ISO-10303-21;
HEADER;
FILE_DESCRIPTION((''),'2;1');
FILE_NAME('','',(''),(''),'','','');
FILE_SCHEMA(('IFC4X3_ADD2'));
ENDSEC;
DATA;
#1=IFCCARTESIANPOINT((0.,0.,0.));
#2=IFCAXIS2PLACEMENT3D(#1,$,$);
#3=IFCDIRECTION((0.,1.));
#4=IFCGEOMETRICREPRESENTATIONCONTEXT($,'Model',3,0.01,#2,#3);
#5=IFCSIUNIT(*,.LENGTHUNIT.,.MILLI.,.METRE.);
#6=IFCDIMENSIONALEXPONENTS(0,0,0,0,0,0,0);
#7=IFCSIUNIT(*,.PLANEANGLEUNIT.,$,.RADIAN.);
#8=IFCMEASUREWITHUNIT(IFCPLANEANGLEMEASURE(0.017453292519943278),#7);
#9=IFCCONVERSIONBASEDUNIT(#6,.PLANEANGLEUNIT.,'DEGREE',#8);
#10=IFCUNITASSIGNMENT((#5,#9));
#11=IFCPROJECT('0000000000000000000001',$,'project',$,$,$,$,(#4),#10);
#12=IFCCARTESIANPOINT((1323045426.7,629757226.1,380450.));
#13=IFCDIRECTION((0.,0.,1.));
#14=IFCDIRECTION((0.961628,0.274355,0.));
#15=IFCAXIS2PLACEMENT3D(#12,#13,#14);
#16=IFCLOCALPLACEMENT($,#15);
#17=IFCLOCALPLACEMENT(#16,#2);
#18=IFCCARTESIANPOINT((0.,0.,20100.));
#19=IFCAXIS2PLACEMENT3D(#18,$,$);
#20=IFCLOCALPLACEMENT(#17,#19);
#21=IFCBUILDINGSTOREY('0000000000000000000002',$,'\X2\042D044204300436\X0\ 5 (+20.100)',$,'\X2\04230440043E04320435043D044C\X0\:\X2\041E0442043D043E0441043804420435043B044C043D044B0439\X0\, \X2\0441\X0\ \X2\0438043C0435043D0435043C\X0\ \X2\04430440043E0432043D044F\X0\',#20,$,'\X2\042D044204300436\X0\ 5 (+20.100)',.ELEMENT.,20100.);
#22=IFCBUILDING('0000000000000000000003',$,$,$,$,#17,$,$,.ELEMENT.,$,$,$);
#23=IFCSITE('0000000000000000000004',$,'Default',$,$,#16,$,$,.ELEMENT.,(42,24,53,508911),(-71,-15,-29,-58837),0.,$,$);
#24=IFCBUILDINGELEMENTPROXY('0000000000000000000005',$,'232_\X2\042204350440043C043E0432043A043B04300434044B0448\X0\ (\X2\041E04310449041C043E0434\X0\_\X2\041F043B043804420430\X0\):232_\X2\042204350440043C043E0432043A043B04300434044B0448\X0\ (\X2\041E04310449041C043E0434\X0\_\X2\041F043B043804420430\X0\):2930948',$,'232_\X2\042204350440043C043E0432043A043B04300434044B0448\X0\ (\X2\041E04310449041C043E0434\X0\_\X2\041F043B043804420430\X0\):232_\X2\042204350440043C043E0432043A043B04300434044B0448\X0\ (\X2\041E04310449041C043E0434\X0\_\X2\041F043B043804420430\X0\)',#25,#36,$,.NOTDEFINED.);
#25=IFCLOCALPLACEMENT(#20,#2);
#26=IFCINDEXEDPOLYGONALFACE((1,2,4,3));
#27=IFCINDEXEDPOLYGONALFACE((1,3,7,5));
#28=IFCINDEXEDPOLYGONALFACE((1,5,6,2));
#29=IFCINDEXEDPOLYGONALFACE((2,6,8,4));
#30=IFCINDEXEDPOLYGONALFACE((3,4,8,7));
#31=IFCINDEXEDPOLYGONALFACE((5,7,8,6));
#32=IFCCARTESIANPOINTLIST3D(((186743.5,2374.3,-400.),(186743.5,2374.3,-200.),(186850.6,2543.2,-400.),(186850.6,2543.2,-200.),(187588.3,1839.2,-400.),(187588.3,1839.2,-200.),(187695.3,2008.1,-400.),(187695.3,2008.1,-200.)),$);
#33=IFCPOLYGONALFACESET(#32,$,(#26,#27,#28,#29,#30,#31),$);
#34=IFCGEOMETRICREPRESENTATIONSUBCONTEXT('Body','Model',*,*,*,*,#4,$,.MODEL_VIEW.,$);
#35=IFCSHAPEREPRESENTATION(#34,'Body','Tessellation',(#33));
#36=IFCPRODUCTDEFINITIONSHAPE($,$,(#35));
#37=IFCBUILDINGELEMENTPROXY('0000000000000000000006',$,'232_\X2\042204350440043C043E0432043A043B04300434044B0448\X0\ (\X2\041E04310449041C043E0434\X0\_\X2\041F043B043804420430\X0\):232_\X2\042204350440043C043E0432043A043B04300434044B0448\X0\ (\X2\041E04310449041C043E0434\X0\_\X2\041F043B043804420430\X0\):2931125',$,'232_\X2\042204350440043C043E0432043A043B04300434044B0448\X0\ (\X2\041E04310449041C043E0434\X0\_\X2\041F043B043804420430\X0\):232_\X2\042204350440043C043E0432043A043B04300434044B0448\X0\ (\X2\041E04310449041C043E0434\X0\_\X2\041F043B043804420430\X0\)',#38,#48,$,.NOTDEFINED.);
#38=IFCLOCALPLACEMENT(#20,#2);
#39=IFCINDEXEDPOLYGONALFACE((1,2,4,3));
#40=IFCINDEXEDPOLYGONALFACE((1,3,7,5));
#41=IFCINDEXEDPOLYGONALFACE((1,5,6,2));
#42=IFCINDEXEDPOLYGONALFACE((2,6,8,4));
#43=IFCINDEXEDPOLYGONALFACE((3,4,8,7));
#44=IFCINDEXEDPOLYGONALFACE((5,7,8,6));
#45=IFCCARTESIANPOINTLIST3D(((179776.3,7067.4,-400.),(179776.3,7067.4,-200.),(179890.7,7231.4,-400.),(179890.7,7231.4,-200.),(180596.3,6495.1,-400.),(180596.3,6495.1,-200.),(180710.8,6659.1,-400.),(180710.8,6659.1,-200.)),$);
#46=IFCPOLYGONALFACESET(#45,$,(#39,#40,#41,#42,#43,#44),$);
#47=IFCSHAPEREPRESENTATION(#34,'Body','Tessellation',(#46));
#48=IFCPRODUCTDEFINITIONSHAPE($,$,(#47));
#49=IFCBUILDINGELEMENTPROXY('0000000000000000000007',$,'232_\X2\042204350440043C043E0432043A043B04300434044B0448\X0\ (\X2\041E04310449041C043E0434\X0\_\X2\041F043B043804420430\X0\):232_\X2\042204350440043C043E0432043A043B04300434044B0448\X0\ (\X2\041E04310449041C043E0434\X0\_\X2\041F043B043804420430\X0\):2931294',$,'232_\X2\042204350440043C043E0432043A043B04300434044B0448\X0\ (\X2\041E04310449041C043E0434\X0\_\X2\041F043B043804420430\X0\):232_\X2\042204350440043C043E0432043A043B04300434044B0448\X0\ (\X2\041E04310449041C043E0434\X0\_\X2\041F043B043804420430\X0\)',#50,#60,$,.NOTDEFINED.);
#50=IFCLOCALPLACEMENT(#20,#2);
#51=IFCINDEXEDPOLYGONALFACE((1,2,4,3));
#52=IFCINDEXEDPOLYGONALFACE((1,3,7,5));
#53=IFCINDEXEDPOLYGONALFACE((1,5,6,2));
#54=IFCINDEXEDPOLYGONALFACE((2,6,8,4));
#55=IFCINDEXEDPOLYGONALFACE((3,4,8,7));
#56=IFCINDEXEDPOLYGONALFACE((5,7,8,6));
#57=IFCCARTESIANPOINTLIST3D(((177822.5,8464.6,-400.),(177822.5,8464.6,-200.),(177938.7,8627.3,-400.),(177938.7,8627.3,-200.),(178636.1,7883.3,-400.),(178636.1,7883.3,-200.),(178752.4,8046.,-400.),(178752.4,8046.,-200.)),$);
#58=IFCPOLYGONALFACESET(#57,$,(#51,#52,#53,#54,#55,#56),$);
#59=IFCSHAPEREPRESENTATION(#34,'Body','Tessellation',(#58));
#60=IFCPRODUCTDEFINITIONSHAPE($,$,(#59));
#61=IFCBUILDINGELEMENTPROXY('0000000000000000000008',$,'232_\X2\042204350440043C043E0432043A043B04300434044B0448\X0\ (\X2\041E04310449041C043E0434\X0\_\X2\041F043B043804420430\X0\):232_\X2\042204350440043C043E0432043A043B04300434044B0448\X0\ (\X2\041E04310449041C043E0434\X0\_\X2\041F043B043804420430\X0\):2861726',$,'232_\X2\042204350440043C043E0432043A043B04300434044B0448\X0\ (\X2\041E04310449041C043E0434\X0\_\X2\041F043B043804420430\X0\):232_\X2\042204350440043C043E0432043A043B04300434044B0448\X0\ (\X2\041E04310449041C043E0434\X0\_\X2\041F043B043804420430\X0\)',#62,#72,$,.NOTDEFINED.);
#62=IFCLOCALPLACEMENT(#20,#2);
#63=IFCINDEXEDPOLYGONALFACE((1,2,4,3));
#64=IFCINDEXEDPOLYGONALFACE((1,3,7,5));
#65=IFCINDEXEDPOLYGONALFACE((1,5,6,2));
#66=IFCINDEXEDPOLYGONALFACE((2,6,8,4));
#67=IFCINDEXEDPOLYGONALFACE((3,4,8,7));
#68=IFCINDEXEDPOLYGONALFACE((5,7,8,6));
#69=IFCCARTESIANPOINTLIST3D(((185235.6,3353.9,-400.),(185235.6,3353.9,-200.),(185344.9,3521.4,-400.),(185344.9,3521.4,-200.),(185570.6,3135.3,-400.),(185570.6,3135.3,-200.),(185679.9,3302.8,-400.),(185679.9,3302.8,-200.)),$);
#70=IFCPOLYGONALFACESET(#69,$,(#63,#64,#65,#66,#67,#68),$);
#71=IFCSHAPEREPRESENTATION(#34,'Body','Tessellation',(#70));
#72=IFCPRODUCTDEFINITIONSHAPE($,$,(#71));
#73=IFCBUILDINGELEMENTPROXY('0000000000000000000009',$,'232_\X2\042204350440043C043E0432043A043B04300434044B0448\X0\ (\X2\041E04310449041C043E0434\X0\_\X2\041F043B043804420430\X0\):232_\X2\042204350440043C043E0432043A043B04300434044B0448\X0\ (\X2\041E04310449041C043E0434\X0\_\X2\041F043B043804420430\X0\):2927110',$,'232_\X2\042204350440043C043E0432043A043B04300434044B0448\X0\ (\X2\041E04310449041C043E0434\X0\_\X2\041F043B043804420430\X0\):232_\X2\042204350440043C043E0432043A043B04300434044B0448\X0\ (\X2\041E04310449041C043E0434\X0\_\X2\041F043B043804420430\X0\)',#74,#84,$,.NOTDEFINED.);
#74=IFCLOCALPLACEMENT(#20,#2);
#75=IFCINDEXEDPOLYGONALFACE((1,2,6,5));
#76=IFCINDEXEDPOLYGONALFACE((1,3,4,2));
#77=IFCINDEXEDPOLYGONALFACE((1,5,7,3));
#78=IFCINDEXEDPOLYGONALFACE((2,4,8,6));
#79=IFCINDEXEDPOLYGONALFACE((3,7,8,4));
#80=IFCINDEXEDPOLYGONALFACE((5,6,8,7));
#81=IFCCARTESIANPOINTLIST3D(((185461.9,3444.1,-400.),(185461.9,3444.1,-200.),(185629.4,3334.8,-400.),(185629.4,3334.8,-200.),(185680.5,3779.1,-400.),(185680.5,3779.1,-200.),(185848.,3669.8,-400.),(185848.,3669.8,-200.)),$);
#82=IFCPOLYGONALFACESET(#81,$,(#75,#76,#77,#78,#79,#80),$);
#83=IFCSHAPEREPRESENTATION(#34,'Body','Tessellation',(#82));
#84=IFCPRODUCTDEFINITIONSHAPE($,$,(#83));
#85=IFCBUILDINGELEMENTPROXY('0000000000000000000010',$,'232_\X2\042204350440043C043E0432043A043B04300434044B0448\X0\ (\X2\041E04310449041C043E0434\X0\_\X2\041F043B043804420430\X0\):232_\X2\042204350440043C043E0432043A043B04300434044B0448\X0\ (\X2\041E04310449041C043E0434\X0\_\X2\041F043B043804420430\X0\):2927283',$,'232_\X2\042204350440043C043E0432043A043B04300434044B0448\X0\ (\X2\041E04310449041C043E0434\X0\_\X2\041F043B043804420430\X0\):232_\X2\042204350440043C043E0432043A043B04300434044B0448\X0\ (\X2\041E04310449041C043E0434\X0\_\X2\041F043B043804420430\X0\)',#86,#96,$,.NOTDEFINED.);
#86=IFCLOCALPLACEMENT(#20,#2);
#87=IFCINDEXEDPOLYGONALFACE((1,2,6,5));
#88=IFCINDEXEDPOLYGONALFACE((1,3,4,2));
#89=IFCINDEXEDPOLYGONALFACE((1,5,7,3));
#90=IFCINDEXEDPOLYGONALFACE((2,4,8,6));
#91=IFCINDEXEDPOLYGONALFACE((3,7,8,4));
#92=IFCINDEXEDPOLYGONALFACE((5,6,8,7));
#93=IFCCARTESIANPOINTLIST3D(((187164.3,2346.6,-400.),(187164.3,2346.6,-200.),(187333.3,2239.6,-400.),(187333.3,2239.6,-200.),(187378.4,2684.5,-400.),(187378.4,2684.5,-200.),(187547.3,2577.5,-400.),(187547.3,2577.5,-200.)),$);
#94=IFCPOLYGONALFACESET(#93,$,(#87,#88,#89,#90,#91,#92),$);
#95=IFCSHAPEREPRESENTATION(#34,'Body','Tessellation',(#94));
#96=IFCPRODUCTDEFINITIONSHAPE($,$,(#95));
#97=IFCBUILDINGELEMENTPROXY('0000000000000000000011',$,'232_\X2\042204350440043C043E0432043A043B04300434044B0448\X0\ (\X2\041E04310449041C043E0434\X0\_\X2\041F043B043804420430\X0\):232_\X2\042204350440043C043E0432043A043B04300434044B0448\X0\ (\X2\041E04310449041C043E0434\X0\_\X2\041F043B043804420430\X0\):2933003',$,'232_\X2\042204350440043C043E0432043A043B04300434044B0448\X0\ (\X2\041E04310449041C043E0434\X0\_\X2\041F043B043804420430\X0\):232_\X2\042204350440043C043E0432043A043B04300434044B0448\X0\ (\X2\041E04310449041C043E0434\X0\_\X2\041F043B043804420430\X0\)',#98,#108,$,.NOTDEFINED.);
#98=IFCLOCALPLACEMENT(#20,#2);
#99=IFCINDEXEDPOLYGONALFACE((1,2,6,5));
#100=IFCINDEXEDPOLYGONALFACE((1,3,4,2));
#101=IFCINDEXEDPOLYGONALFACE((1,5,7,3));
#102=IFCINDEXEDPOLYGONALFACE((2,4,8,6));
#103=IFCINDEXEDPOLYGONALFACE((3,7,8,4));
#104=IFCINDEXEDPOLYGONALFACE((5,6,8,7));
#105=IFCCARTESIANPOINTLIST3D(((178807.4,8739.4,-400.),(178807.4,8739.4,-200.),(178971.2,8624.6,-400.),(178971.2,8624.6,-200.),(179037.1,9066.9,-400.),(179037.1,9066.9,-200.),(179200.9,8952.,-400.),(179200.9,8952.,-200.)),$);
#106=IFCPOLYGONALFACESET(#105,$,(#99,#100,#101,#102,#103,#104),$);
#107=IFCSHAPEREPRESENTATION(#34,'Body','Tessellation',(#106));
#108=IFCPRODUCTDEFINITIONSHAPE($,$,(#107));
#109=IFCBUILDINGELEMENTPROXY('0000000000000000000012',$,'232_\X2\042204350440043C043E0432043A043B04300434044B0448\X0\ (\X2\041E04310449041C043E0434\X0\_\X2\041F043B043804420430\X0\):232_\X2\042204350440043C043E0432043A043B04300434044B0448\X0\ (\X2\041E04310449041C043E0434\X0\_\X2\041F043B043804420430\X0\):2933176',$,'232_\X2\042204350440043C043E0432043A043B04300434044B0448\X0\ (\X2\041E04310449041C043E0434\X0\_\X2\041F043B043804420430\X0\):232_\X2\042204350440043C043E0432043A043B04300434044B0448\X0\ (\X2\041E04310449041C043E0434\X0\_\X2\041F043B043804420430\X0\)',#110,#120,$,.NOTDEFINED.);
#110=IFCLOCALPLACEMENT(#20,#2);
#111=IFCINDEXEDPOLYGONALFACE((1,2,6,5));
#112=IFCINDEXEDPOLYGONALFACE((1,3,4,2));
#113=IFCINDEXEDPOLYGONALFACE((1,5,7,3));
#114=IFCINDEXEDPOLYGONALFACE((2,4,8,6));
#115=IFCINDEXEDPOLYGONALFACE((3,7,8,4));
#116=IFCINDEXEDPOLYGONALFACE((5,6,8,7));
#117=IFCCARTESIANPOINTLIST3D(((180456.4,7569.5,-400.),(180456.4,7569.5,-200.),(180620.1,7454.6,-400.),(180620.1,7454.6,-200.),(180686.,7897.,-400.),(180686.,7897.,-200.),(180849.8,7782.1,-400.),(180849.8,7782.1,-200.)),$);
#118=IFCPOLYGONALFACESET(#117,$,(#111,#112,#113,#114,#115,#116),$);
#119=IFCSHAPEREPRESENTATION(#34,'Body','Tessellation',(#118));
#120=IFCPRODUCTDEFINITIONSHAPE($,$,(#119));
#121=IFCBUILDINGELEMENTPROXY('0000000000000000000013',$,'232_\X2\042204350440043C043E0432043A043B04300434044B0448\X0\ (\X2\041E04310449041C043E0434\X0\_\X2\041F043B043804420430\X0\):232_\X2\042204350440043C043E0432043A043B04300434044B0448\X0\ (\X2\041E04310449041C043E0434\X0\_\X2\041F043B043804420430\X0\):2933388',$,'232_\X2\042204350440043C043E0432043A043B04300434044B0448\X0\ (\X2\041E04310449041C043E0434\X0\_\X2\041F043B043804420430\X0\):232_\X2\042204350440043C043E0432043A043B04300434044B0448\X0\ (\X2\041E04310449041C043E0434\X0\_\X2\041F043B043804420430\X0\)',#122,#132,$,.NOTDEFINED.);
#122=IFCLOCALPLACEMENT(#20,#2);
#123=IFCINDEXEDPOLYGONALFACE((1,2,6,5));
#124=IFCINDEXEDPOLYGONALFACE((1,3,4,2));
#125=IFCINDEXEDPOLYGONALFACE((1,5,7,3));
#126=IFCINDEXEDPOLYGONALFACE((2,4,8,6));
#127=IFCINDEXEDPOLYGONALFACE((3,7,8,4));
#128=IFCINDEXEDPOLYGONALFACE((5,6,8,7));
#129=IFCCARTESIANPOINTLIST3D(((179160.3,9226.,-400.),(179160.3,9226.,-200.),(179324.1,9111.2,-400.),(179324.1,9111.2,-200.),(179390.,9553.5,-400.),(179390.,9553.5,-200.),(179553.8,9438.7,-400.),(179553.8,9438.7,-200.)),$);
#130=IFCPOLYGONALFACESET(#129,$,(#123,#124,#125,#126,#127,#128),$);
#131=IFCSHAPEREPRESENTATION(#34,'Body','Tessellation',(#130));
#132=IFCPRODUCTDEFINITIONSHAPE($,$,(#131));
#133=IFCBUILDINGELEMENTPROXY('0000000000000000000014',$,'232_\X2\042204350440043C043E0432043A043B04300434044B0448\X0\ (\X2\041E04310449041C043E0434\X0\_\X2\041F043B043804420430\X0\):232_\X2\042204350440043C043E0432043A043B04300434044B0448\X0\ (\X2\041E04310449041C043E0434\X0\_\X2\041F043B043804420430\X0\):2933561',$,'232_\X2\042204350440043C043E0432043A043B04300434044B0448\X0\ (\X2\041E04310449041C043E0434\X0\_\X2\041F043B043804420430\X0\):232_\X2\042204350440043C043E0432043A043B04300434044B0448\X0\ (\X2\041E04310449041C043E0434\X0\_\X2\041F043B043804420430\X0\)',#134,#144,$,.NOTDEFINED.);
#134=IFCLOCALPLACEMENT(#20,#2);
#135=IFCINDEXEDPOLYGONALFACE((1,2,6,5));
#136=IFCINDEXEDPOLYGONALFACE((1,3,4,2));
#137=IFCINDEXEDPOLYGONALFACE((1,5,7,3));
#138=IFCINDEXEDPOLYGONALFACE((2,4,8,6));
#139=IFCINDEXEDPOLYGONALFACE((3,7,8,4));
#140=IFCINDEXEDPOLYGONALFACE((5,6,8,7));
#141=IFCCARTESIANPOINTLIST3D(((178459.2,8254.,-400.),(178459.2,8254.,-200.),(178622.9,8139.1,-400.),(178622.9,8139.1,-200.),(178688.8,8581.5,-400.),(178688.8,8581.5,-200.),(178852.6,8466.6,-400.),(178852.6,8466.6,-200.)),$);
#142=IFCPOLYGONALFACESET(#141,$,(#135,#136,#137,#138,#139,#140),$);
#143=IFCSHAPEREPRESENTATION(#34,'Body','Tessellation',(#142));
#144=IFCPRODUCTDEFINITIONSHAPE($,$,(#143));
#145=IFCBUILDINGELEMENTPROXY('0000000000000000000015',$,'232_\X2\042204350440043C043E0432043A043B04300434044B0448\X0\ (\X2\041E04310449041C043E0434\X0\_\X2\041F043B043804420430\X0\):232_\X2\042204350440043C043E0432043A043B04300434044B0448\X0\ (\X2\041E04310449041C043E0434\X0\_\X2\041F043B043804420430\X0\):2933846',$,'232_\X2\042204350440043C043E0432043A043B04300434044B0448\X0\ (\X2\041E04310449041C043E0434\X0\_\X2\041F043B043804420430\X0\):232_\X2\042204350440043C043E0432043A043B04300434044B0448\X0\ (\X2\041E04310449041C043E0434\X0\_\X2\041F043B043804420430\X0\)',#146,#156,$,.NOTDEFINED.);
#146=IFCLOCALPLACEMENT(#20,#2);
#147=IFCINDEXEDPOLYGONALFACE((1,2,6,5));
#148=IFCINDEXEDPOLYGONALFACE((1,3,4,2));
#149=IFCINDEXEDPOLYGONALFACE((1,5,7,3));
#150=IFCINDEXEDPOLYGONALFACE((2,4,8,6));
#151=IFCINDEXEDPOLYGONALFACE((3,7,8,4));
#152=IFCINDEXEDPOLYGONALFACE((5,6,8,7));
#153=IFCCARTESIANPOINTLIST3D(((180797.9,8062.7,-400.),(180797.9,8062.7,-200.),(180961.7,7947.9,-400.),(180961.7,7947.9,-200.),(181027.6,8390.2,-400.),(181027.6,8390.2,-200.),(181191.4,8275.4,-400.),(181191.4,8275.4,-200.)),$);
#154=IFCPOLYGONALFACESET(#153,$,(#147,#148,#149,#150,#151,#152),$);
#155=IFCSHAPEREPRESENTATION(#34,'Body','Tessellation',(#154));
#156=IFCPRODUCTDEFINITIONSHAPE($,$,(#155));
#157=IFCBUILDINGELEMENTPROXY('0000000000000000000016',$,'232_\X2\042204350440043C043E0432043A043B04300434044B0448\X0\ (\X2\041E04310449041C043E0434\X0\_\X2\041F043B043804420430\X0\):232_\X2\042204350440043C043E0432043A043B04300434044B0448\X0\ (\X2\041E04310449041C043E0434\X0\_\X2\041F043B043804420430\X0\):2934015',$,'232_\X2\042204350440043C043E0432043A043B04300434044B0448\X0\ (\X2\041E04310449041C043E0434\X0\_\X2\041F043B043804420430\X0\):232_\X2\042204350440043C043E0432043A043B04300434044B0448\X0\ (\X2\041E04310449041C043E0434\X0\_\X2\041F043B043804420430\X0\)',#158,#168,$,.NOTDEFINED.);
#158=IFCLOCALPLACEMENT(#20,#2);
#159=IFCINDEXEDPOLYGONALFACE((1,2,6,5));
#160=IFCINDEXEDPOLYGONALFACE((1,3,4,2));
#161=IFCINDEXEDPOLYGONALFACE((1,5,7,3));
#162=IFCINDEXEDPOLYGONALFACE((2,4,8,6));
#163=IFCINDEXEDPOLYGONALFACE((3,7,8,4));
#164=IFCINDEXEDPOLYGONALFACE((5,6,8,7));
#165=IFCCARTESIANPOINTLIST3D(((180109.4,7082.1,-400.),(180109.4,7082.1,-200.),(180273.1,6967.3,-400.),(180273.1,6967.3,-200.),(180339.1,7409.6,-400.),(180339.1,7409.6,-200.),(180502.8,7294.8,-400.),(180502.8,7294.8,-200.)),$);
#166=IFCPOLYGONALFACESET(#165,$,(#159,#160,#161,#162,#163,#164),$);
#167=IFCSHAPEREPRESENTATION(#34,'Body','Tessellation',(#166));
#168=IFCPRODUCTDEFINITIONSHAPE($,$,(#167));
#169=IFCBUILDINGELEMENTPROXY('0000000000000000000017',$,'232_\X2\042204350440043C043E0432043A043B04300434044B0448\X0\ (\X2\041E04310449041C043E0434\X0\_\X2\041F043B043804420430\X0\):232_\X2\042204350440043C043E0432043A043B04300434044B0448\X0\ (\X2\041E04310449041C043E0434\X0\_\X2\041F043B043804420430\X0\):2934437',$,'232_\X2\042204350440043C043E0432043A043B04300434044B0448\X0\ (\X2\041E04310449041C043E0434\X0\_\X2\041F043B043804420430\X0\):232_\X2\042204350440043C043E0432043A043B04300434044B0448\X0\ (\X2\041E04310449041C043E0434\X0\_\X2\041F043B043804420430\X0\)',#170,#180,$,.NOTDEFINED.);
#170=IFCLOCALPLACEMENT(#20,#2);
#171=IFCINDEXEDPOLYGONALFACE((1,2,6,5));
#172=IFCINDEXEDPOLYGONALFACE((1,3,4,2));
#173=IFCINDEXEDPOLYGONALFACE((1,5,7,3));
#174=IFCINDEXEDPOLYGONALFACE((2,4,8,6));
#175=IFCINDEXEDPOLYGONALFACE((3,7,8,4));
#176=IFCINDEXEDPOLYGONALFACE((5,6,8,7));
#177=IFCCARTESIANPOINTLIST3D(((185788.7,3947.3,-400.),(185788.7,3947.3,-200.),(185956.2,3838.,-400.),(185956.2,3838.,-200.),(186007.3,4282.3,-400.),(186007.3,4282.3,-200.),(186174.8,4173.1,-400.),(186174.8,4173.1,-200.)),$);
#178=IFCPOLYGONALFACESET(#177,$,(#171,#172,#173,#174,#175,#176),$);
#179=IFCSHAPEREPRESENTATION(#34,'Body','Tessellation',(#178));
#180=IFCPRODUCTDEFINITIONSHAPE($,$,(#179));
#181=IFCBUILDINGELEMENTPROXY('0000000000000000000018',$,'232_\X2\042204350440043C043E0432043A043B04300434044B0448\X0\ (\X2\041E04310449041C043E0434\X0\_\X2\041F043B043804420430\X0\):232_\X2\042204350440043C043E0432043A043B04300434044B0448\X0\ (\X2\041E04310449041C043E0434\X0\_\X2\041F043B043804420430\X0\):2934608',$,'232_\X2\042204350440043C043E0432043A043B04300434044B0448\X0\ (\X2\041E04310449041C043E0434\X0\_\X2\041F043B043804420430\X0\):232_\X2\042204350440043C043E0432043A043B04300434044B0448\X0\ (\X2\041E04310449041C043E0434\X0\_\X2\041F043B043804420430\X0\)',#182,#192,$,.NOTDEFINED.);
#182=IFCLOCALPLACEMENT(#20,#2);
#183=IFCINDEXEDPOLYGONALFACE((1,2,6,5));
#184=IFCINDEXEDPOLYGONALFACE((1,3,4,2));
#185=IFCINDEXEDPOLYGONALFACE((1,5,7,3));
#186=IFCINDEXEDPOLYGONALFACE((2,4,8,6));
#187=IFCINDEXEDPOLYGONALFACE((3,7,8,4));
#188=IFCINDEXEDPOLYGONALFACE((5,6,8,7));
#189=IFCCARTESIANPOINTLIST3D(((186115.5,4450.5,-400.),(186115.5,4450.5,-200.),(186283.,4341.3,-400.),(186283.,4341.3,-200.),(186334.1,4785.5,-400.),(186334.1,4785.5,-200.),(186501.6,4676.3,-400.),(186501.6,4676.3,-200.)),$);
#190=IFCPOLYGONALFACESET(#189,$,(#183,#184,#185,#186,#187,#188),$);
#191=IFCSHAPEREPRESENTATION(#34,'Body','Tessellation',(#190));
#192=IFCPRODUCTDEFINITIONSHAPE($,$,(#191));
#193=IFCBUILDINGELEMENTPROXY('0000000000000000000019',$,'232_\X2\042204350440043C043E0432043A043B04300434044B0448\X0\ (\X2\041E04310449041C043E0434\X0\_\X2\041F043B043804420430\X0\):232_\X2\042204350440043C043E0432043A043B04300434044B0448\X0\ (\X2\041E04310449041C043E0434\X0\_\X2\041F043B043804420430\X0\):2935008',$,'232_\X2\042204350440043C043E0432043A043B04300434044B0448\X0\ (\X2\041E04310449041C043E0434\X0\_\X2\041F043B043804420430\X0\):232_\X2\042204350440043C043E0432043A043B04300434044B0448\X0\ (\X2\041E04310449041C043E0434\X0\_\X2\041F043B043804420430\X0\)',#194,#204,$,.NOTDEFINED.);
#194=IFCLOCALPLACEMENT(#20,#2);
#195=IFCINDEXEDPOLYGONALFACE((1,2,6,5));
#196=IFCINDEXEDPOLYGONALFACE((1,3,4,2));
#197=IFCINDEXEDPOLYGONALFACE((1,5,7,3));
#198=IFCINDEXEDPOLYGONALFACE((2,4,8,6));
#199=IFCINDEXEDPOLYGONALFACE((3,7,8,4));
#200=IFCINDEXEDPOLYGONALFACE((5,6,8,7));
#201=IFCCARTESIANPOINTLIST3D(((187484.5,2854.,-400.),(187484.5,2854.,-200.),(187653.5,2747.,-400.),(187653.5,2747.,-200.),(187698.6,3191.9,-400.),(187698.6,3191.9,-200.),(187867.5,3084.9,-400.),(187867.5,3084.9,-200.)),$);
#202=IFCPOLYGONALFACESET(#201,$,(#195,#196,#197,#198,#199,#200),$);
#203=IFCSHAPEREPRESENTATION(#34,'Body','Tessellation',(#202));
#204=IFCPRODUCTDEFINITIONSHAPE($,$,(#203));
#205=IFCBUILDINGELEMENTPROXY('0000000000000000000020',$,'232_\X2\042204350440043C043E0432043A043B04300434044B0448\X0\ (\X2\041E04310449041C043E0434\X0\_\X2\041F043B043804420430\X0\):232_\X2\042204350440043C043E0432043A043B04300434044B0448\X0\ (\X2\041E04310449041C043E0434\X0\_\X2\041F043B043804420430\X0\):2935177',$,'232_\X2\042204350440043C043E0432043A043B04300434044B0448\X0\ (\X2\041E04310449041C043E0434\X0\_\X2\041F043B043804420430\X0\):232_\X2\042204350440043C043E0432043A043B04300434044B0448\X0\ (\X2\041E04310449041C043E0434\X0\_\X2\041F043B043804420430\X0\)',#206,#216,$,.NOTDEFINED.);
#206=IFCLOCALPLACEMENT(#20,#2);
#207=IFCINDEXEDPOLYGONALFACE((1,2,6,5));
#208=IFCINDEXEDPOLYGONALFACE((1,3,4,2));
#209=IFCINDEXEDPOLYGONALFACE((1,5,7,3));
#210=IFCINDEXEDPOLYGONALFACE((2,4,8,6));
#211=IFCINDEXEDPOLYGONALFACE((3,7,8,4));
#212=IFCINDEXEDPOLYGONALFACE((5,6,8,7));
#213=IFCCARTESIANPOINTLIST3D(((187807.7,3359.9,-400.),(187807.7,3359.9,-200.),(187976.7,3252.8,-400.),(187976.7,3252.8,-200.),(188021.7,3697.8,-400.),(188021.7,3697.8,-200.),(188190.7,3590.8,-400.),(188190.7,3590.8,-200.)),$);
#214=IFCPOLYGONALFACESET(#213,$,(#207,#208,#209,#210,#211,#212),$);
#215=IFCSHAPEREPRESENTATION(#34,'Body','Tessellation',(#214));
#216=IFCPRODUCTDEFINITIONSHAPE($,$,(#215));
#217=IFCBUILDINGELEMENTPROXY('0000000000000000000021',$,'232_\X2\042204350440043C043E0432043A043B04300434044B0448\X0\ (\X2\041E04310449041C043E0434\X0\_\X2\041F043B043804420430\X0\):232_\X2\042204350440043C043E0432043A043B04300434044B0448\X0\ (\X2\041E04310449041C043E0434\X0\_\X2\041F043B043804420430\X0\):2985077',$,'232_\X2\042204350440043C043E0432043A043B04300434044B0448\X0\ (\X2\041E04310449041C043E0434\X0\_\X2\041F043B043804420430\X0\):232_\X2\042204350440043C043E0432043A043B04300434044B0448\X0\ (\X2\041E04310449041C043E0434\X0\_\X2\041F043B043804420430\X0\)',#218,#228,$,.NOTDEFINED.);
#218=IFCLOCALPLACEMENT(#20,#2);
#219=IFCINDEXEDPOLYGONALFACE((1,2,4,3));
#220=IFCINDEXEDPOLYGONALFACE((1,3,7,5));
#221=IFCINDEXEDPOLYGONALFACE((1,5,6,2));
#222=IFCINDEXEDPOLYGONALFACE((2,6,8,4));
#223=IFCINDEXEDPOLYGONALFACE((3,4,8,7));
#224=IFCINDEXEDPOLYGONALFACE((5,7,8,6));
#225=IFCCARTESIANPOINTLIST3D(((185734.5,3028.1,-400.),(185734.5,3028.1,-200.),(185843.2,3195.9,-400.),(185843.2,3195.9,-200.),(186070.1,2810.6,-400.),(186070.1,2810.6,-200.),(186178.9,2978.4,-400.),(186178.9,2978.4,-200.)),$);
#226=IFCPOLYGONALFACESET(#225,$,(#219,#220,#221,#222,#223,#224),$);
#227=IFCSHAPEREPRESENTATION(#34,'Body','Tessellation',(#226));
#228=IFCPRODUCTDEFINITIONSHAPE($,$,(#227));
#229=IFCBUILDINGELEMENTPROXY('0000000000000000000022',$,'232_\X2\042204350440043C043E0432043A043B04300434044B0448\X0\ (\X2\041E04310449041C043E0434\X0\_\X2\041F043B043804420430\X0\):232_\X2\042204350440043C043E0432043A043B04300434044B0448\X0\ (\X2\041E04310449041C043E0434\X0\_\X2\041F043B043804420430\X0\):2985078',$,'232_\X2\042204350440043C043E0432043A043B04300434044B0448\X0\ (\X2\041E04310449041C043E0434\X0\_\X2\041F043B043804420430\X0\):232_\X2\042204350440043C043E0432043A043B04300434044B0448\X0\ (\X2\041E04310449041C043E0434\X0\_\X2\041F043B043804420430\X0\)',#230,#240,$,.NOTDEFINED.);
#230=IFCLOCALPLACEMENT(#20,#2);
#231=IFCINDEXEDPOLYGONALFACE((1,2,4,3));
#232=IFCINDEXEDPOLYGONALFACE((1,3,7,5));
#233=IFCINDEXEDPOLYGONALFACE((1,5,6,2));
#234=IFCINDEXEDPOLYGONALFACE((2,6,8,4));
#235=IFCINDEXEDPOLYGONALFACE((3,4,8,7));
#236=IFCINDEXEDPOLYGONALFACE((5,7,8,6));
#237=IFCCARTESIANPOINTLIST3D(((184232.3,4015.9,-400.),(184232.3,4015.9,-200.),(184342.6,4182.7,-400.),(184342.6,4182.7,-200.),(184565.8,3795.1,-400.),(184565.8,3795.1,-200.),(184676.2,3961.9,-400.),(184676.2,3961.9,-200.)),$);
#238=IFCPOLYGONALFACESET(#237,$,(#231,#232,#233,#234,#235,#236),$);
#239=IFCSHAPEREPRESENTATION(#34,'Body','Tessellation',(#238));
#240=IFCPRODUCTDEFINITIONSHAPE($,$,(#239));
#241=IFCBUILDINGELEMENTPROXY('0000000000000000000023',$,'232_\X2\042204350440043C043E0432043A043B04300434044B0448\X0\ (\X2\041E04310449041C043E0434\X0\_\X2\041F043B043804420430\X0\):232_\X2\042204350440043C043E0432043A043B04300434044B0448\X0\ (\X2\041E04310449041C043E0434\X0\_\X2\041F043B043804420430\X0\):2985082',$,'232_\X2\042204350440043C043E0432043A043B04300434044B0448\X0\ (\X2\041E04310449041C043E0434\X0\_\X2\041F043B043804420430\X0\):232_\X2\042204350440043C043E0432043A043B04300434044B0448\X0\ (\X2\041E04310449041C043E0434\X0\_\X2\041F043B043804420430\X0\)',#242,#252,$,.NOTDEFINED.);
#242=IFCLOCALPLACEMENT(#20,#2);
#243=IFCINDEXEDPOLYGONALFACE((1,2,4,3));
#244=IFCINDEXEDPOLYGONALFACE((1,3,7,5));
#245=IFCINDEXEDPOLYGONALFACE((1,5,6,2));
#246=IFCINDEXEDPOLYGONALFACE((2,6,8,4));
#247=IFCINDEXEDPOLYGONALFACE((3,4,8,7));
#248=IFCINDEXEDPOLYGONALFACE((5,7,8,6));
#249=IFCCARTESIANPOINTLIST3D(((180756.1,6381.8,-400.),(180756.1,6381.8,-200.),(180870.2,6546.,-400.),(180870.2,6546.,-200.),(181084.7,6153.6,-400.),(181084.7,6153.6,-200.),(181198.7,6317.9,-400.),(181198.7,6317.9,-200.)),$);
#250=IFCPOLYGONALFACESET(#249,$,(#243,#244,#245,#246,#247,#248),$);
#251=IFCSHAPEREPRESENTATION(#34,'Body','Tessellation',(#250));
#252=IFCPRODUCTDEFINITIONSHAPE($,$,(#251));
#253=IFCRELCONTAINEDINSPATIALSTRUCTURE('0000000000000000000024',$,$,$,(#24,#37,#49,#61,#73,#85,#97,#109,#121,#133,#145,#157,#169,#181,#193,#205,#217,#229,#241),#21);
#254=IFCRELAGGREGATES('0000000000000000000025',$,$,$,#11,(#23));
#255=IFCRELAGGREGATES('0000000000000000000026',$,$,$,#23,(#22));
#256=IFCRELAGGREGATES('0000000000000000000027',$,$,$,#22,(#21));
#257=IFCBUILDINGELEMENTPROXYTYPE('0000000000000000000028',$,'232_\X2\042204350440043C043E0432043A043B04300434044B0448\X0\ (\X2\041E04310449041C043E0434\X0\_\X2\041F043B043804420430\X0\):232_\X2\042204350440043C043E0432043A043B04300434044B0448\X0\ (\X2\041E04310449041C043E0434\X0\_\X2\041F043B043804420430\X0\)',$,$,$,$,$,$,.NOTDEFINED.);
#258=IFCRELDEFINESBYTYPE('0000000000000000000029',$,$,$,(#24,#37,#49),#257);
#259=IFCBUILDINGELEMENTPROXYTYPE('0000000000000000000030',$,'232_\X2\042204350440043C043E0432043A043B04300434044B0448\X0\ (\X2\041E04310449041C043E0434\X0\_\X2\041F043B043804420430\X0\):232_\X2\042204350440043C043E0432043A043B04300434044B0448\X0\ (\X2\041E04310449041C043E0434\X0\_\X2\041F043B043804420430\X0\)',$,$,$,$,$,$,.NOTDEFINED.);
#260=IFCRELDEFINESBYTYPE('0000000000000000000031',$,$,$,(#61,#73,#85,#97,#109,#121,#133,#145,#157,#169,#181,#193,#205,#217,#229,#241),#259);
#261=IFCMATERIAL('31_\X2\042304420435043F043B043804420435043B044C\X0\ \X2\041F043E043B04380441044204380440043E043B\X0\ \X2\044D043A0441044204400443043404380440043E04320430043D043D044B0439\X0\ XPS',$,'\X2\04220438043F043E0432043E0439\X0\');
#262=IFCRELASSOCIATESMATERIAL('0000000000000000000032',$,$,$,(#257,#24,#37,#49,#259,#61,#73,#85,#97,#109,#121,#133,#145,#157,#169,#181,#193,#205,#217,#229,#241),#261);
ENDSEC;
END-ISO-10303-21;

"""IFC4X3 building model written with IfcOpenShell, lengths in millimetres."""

from ifc_helpers import new_model, entity, si_unit, converted_unit, direction, frame, origin, origin_2d_with_axis, place, context, subcontext, project, spatial, rectangle, extrude, source, transform, mapped, material, type_object, type_shapes, element, save


model = new_model("IFC4X3")

# Units and contexts
model_context = context("Model", 3, precision=0.01, world=origin(), true_north=direction((0.0, 1.0)))
body_context = subcontext(model_context, "Body", "Model", "MODEL_VIEW")
ifc_project = project(units=[si_unit("LENGTHUNIT", "METRE", prefix="MILLI"), converted_unit("PLANEANGLEUNIT", "DEGREE", entity("IfcPlaneAngleMeasure", 0.017453292519943278), si_unit("PLANEANGLEUNIT", "RADIAN"), dimensions=[0, 0, 0, 0, 0, 0, 0])], contexts=[model_context])

# Site, building, storey
site_placement = place(None, frame((1323045426.7, 629757226.1, 380450.0), z_axis=(0.0, 0.0, 1.0), x_axis=(0.961628, 0.274355, 0.0)))
site = spatial("IfcSite", under=ifc_project, at=site_placement, Name="Default", CompositionType="ELEMENT", RefLatitude=(42, 24, 53, 508911), RefLongitude=(-71, -15, -29, -58837), RefElevation=0.0)
building_placement = place(site_placement, origin())
building = spatial("IfcBuilding", under=site, at=building_placement, CompositionType="ELEMENT")
storey_placement = place(building_placement, frame((0.0, 0.0, 20100.0)))
storey = spatial("IfcBuildingStorey", under=building, at=storey_placement, Name="Этаж 5 (+20.100)", ObjectType="Уровень:Относительный, с именем уровня", LongName="Этаж 5 (+20.100)", CompositionType="ELEMENT", Elevation=20100.0)

# Building element proxies
ifc_material = material(Name="31_Утеплитель Полистирол экструдированный XPS", Category="Типовой")
building_element_proxy_type_1 = type_object("IfcBuildingElementProxyType", Name="232_Термовкладыш (ОбщМод_Плита):232_Термовкладыш (ОбщМод_Плита)", PredefinedType="NOTDEFINED", material=ifc_material)
shared_shape_1 = source(origin(), body_context, "Body", "SweptSolid", [
    extrude(rectangle(XDim=1000.0, YDim=200.0, at=origin_2d_with_axis()), frame((500.0, 0.0, -200.0), z_axis=(0.0, 0.0, 1.0), x_axis=(-1.0, 0.0, 0.0)), (0.0, 0.0, 1.0), 200.0),
])
type_shapes(building_element_proxy_type_1, [shared_shape_1])
for number, where, z_axis, x_axis, name in (
    (1, (187641.8, 1923.7, -200.0), (0.0, 0.0, 1.0), (-0.844789, 0.535099, 0.0), "232_Термовкладыш (ОбщМод_Плита):232_Термовкладыш (ОбщМод_Плита):2930948"),
    (2, (180653.5, 6577.1, -200.0), (0.0, 0.0, 1.0), (-0.820037, 0.572311, 0.0), "232_Термовкладыш (ОбщМод_Плита):232_Термовкладыш (ОбщМод_Плита):2931125"),
    (3, (178694.3, 7964.6, -200.0), (0.0, 0.0, 1.0), (-0.813663, 0.581337, 0.0), "232_Термовкладыш (ОбщМод_Плита):232_Термовкладыш (ОбщМод_Плита):2931294"),
):
    element("IfcBuildingElementProxy", number, at=place(storey_placement, frame(where, z_axis=z_axis, x_axis=x_axis)), inside=storey, type_object=building_element_proxy_type_1, material=ifc_material, Name=name, ObjectType="232_Термовкладыш (ОбщМод_Плита):232_Термовкладыш (ОбщМод_Плита)", PredefinedType="NOTDEFINED", context=body_context, shape_type="MappedRepresentation", body=[
        mapped(shared_shape_1, transform((0.0, 0.0, 0.0), scale=1.0)),
    ])
building_element_proxy_type_2 = type_object("IfcBuildingElementProxyType", Name="232_Термовкладыш (ОбщМод_Плита):232_Термовкладыш (ОбщМод_Плита)", PredefinedType="NOTDEFINED", material=ifc_material)
shared_shape_2 = source(origin(), body_context, "Body", "SweptSolid", [
    extrude(rectangle(XDim=400.0, YDim=200.0, at=origin_2d_with_axis()), frame((200.0, 0.0, -200.0), z_axis=(0.0, 0.0, 1.0), x_axis=(-1.0, 0.0, 0.0)), (0.0, 0.0, 1.0), 200.0),
])
type_shapes(building_element_proxy_type_2, [shared_shape_2])
for number, where, z_axis, x_axis, name in (
    (4, (185625.2, 3219.0, -200.0), (0.0, 0.0, 1.0), (-0.837417, 0.546565, 0.0), "232_Термовкладыш (ОбщМод_Плита):232_Термовкладыш (ОбщМод_Плита):2861726"),
    (5, (185545.7, 3389.5, -200.0), (0.0, 0.0, 1.0), (0.546423, 0.83751, 0.0), "232_Термовкладыш (ОбщМод_Плита):232_Термовкладыш (ОбщМод_Плита):2927110"),
    (6, (187248.8, 2293.1, -200.0), (0.0, 0.0, 1.0), (0.535099, 0.844789, 0.0), "232_Термовкладыш (ОбщМод_Плита):232_Термовкладыш (ОбщМод_Плита):2927283"),
    (7, (178889.3, 8682.0, -200.0), (0.0, 0.0, 1.0), (0.574185, 0.818726, 0.0), "232_Термовкладыш (ОбщМод_Плита):232_Термовкладыш (ОбщМод_Плита):2933003"),
    (8, (180538.2, 7512.0, -200.0), (0.0, 0.0, 1.0), (0.574185, 0.818726, 0.0), "232_Термовкладыш (ОбщМод_Плита):232_Термовкладыш (ОбщМод_Плита):2933176"),
    (9, (179242.2, 9168.6, -200.0), (0.0, 0.0, 1.0), (0.574185, 0.818726, 0.0), "232_Термовкладыш (ОбщМод_Плита):232_Термовкладыш (ОбщМод_Плита):2933388"),
    (10, (178541.0, 8196.6, -200.0), (0.0, 0.0, 1.0), (0.574185, 0.818726, 0.0), "232_Термовкладыш (ОбщМод_Плита):232_Термовкладыш (ОбщМод_Плита):2933561"),
    (11, (180879.8, 8005.3, -200.0), (0.0, 0.0, 1.0), (0.574185, 0.818726, 0.0), "232_Термовкладыш (ОбщМод_Плита):232_Термовкладыш (ОбщМод_Плита):2933846"),
    (12, (180191.3, 7024.7, -200.0), (0.0, 0.0, 1.0), (0.574185, 0.818726, 0.0), "232_Термовкладыш (ОбщМод_Плита):232_Термовкладыш (ОбщМод_Плита):2934015"),
    (13, (185872.5, 3892.7, -200.0), (0.0, 0.0, 1.0), (0.546423, 0.83751, 0.0), "232_Термовкладыш (ОбщМод_Плита):232_Термовкладыш (ОбщМод_Плита):2934437"),
    (14, (186199.2, 4395.9, -200.0), (0.0, 0.0, 1.0), (0.546423, 0.83751, 0.0), "232_Термовкладыш (ОбщМод_Плита):232_Термовкладыш (ОбщМод_Плита):2934608"),
    (15, (187569.0, 2800.5, -200.0), (0.0, 0.0, 1.0), (0.535099, 0.844789, 0.0), "232_Термовкладыш (ОбщМод_Плита):232_Термовкладыш (ОбщМод_Плита):2935008"),
    (16, (187892.2, 3306.4, -200.0), (0.0, 0.0, 1.0), (0.535099, 0.844789, 0.0), "232_Термовкладыш (ОбщМод_Плита):232_Термовкладыш (ОбщМод_Плита):2935177"),
    (17, (186124.5, 2894.5, -200.0), (0.0, 0.0, 1.0), (-0.839155, 0.543893, 0.0), "232_Термовкладыш (ОбщМод_Плита):232_Термовкладыш (ОбщМод_Плита):2985077"),
    (18, (184621.0, 3878.5, -200.0), (0.0, 0.0, 1.0), (-0.833916, 0.551892, 0.0), "232_Термовкладыш (ОбщМод_Плита):232_Термовкладыш (ОбщМод_Плита):2985078"),
    (19, (181141.7, 6235.8, -200.0), (0.0, 0.0, 1.0), (-0.821396, 0.570358, 0.0), "232_Термовкладыш (ОбщМод_Плита):232_Термовкладыш (ОбщМод_Плита):2985082"),
):
    element("IfcBuildingElementProxy", number, at=place(storey_placement, frame(where, z_axis=z_axis, x_axis=x_axis)), inside=storey, type_object=building_element_proxy_type_2, material=ifc_material, Name=name, ObjectType="232_Термовкладыш (ОбщМод_Плита):232_Термовкладыш (ОбщМод_Плита)", PredefinedType="NOTDEFINED", context=body_context, shape_type="MappedRepresentation", body=[
        mapped(shared_shape_2, transform((0.0, 0.0, 0.0), scale=1.0)),
    ])

save(model, "model.ifc")
